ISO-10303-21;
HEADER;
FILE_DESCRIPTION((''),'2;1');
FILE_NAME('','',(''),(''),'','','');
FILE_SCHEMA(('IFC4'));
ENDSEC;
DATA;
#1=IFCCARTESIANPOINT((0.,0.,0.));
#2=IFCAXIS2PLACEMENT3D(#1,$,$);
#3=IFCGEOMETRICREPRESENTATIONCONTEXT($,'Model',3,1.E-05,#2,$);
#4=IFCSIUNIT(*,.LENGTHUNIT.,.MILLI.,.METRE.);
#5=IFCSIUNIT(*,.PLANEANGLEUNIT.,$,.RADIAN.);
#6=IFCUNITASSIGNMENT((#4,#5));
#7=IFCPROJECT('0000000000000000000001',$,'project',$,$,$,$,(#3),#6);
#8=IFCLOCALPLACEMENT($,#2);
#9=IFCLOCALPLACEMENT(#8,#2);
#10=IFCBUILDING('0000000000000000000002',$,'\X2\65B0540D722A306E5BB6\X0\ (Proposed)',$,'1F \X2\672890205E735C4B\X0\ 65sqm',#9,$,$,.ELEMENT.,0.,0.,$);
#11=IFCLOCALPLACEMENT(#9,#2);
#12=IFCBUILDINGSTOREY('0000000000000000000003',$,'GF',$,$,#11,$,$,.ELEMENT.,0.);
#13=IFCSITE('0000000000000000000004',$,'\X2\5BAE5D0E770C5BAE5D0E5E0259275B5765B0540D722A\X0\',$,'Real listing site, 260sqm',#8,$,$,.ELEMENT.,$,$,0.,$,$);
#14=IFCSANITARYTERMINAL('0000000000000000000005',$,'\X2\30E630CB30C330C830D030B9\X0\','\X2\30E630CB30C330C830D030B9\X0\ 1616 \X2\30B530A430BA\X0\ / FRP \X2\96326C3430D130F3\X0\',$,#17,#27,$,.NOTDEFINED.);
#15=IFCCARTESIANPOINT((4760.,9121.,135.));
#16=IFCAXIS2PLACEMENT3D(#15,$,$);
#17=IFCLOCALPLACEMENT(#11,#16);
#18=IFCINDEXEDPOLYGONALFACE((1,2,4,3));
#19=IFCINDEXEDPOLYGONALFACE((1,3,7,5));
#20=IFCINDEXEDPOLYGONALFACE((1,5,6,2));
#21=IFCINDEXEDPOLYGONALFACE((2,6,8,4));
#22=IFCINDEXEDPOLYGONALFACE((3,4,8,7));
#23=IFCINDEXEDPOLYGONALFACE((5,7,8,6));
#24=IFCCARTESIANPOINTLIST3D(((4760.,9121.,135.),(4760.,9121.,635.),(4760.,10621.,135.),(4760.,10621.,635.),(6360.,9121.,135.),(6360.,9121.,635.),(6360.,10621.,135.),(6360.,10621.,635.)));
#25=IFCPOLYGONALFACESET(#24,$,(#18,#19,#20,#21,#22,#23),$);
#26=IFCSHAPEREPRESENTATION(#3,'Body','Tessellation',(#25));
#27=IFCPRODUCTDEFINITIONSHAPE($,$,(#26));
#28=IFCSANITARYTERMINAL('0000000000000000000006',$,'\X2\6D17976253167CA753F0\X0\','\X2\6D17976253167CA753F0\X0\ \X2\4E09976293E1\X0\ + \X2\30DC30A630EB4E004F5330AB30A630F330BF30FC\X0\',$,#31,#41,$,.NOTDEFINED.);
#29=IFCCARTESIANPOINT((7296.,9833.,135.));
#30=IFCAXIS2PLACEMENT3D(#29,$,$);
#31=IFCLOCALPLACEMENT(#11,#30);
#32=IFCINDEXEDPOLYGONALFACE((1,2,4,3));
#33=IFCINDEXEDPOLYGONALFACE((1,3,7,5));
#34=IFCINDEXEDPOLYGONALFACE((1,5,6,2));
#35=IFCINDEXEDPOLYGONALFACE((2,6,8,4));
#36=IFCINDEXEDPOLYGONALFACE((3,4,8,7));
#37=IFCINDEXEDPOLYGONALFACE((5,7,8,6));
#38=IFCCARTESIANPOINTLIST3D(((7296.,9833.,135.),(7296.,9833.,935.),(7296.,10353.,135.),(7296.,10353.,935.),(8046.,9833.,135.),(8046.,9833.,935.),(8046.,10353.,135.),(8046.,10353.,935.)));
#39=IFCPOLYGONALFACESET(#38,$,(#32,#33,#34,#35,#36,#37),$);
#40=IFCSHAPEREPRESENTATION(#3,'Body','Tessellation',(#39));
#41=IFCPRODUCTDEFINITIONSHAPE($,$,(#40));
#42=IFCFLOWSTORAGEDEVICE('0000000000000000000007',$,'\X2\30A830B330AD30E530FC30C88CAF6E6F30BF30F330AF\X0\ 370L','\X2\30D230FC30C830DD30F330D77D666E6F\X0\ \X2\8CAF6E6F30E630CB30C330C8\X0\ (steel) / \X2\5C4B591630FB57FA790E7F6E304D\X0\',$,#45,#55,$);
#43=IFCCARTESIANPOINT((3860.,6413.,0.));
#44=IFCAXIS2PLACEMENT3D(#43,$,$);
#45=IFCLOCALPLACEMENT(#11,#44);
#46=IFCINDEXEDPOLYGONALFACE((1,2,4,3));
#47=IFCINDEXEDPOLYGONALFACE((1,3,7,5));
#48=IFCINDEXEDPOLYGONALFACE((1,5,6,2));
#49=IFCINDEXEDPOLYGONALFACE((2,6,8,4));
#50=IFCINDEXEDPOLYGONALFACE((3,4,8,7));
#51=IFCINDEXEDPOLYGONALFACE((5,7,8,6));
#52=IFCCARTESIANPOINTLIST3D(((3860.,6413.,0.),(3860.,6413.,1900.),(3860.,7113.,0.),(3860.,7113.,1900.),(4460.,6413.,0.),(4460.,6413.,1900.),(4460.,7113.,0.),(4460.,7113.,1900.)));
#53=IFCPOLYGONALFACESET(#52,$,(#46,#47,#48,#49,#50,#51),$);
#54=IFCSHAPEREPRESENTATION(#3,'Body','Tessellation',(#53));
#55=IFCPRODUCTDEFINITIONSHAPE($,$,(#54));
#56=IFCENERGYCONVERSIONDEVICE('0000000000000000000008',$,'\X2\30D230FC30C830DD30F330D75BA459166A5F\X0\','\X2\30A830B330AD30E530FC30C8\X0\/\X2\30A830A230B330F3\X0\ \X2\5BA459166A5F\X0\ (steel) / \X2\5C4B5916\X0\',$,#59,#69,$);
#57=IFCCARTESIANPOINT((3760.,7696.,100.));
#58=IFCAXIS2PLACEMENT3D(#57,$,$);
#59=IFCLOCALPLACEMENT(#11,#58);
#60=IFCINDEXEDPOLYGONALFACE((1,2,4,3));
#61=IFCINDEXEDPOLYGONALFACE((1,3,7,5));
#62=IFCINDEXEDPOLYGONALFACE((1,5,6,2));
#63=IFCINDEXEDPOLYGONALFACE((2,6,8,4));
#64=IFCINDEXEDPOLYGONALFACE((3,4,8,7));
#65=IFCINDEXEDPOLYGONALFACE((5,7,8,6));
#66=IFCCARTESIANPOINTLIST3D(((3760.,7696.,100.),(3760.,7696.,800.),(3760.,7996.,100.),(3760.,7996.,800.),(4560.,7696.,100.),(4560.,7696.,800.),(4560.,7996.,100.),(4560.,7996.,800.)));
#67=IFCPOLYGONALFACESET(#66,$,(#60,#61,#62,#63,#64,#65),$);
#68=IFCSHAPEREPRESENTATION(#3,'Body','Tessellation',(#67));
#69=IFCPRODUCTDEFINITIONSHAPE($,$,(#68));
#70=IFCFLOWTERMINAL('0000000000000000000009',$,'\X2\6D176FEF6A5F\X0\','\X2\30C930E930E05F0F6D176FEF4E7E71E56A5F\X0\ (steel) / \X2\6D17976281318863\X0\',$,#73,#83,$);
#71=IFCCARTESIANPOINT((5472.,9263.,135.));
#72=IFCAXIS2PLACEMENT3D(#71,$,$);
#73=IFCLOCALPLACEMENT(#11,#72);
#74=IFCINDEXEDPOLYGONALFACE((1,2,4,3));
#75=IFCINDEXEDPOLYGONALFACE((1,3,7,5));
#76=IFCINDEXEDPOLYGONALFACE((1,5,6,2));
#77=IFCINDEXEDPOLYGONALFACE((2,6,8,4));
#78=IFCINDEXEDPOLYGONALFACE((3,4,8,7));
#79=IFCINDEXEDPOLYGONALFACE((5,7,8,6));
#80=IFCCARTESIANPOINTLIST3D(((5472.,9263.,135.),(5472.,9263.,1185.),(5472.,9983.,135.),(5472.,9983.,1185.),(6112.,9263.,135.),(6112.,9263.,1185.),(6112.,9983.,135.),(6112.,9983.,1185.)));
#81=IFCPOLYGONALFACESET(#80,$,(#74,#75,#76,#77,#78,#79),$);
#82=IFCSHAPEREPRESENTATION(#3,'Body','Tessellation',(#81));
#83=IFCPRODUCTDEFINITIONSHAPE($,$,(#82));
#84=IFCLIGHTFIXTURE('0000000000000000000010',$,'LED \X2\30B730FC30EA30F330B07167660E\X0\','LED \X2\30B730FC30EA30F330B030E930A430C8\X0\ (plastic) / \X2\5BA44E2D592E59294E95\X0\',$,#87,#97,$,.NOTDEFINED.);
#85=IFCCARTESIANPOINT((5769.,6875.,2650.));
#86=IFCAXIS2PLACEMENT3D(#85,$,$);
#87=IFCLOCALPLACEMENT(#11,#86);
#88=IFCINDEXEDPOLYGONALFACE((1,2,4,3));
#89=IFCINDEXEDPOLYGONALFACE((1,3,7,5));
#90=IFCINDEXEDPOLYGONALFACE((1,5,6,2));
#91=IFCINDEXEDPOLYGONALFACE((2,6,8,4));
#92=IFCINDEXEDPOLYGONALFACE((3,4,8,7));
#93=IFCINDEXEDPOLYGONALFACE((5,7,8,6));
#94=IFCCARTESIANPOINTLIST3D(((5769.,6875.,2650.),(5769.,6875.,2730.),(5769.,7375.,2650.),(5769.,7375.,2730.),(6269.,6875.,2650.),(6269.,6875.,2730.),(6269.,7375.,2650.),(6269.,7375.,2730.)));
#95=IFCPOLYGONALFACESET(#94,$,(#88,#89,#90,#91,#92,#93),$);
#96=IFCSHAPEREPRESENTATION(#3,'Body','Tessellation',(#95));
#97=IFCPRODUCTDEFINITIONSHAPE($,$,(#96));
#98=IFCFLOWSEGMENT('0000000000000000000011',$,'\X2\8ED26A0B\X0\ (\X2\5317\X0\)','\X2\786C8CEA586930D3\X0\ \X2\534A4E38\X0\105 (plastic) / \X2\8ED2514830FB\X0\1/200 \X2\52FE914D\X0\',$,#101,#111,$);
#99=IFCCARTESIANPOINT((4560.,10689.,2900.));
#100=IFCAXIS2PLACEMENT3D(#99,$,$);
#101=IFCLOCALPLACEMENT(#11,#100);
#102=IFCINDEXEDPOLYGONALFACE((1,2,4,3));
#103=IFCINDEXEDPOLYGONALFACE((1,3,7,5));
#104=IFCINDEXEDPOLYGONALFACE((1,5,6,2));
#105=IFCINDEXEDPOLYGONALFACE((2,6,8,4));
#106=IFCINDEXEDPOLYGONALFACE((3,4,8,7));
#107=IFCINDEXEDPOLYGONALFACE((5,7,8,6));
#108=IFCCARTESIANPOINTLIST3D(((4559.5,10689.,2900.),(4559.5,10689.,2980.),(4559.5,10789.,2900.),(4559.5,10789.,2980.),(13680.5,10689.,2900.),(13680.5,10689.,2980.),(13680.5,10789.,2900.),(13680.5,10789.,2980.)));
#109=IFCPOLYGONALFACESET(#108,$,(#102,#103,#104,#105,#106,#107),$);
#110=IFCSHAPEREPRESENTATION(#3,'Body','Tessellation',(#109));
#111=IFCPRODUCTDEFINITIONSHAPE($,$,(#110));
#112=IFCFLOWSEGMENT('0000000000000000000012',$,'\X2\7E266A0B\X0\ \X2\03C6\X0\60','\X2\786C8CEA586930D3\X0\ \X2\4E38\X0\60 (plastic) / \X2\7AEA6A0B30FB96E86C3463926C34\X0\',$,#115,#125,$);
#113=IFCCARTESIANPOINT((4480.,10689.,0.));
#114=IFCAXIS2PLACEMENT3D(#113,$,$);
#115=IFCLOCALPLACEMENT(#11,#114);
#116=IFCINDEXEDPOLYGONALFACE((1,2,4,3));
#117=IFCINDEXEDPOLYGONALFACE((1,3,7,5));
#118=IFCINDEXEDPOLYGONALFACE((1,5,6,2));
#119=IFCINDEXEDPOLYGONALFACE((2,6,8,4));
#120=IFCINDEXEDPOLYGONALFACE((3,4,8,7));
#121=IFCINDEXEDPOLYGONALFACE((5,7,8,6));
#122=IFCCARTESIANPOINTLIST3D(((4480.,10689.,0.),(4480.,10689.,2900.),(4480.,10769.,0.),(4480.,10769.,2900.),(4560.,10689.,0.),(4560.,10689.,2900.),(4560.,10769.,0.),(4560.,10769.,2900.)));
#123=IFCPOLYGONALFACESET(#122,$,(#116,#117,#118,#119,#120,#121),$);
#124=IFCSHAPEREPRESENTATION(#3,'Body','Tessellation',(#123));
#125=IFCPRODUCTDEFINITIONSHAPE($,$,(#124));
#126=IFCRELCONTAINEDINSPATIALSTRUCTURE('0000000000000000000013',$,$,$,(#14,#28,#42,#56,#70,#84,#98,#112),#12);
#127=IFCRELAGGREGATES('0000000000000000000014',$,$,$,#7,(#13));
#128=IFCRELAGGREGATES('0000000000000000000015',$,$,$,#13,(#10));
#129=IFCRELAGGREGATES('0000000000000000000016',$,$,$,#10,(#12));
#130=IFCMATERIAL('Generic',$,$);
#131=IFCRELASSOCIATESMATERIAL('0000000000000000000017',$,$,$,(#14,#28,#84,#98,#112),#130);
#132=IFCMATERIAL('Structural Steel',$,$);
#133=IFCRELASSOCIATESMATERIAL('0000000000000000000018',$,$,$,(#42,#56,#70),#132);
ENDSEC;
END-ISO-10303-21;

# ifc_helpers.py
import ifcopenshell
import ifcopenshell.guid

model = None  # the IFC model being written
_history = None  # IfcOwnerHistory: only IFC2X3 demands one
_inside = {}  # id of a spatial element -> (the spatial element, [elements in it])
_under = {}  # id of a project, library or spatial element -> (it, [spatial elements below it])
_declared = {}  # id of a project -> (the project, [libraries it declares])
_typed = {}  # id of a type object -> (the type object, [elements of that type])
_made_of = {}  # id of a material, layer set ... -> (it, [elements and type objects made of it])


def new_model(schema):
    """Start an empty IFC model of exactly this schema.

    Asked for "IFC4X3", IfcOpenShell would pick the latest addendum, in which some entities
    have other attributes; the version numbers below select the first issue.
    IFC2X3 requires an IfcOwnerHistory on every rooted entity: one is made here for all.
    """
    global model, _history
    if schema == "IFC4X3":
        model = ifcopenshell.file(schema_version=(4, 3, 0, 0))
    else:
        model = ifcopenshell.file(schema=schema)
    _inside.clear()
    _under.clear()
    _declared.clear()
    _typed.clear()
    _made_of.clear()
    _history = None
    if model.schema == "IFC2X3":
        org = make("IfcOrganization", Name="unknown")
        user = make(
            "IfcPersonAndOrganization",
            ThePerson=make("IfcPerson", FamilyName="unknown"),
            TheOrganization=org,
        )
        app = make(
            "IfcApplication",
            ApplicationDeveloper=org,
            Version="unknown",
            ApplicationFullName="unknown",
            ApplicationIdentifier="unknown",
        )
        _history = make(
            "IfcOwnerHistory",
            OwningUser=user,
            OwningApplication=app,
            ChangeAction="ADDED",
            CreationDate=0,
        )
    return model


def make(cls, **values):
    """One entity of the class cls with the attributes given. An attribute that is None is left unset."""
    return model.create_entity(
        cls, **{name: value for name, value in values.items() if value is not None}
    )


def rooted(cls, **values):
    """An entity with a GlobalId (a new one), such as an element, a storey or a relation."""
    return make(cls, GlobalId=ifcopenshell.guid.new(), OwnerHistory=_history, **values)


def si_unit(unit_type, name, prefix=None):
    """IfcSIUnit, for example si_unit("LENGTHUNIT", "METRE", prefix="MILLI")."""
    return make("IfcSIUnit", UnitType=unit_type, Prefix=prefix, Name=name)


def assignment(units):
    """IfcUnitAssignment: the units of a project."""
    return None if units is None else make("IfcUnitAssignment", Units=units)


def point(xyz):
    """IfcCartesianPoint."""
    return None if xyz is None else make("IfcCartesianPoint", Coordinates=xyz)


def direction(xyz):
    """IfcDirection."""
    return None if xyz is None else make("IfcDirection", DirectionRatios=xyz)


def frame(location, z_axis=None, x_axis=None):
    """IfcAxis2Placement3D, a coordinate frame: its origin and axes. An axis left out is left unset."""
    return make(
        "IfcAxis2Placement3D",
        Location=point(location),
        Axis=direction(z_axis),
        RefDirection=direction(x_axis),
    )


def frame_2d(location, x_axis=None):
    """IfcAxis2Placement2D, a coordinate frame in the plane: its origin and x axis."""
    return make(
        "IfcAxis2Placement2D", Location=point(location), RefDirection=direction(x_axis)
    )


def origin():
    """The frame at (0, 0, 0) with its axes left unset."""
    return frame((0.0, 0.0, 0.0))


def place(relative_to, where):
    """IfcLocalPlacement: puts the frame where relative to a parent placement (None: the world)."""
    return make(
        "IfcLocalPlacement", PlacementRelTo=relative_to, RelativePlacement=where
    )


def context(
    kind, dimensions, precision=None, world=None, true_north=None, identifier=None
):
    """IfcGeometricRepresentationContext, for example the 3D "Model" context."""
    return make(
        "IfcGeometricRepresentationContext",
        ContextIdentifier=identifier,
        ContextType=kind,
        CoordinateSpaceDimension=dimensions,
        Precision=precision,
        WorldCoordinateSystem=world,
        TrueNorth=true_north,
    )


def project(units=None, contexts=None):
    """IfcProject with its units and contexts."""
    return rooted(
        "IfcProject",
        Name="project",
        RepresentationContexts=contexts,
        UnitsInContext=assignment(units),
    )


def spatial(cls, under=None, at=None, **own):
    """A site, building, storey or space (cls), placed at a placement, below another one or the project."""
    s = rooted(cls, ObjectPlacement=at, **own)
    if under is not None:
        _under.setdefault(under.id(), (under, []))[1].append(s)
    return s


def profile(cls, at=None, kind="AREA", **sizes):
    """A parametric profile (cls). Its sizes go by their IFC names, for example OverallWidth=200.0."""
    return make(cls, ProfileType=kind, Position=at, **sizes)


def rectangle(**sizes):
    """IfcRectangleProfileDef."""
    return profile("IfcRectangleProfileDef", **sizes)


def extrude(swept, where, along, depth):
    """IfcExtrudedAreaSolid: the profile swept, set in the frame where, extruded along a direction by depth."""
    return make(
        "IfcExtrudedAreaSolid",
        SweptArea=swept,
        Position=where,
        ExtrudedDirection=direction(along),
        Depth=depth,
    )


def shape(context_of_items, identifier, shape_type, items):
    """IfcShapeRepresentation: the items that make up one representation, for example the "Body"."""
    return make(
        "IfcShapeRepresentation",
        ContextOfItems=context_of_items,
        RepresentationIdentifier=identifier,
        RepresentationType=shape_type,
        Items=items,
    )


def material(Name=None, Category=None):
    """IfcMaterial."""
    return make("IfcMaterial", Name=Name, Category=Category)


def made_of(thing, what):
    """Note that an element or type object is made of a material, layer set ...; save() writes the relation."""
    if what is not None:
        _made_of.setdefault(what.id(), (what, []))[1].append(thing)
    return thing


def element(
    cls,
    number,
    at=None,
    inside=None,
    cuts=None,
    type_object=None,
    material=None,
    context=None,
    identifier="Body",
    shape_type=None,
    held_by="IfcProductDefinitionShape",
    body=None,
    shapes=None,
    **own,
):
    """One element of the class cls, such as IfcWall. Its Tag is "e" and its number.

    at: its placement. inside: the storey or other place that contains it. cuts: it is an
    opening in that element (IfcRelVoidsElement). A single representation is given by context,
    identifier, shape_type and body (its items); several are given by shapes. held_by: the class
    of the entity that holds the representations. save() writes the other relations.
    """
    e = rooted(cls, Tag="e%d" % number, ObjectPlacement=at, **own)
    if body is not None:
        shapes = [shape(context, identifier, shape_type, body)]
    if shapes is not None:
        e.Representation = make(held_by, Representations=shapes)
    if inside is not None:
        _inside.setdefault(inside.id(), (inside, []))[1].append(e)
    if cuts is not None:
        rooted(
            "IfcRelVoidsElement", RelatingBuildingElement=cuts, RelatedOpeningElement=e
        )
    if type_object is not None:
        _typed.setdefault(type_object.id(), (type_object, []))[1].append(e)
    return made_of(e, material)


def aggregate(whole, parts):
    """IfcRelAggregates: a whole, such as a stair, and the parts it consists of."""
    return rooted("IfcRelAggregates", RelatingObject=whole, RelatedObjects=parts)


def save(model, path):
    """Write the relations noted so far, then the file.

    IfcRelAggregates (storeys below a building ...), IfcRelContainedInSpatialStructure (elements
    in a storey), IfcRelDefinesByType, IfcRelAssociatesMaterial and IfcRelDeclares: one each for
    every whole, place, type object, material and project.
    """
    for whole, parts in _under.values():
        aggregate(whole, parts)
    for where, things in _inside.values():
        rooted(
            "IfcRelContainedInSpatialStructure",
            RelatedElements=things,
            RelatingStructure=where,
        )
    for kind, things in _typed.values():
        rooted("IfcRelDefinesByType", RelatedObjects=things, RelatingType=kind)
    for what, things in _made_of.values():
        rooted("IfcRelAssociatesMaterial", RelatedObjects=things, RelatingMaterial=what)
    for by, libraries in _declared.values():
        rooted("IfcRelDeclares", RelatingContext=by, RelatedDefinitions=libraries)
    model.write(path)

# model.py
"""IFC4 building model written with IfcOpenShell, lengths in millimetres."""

from ifc_helpers import new_model, si_unit, frame, frame_2d, origin, place, context, project, spatial, rectangle, extrude, material, element, save


model = new_model("IFC4")

# Units and contexts
model_context = context("Model", 3, precision=1e-05, world=origin())
ifc_project = project(units=[si_unit("LENGTHUNIT", "METRE", prefix="MILLI"), si_unit("PLANEANGLEUNIT", "RADIAN")], contexts=[model_context])

# Site, building, storey
site_placement = place(None, origin())
site = spatial("IfcSite", under=ifc_project, at=site_placement, Name="宮崎県宮崎市大字新名爪", ObjectType="Real listing site, 260sqm", CompositionType="ELEMENT", RefElevation=0.0)
building_placement = place(site_placement, origin())
building = spatial("IfcBuilding", under=site, at=building_placement, Name="新名爪の家 (Proposed)", ObjectType="1F 木造平屋 65sqm", CompositionType="ELEMENT", ElevationOfRefHeight=0.0, ElevationOfTerrain=0.0)
storey_placement = place(building_placement, origin())
storey = spatial("IfcBuildingStorey", under=building, at=storey_placement, Name="GF", CompositionType="ELEMENT", Elevation=0.0)

# Shared definitions
ifc_material_1 = material(Name="Structural Steel")

# Shared definitions
ifc_material_2 = material(Name="Generic")

# Sanitary terminals
sanitary_terminal_1_placement = place(storey_placement, frame((4760.0, 9121.0, 135.0)))
element("IfcSanitaryTerminal", 1, at=sanitary_terminal_1_placement, inside=storey, material=ifc_material_2, Name="ユニットバス", Description="ユニットバス 1616 サイズ / FRP 防水パン", PredefinedType="NOTDEFINED", context=model_context, shape_type="SweptSolid", body=[
    extrude(rectangle(XDim=1600.0, YDim=1500.0, at=frame_2d((800.0, 750.0))), frame((4760.0, 9121.0, 135.0)), (0.0, 0.0, 1.0), 500.0),
])
sanitary_terminal_2_placement = place(storey_placement, frame((7296.0, 9833.0, 135.0)))
element("IfcSanitaryTerminal", 2, at=sanitary_terminal_2_placement, inside=storey, material=ifc_material_2, Name="洗面化粧台", Description="洗面化粧台 三面鏡 + ボウル一体カウンター", PredefinedType="NOTDEFINED", context=model_context, shape_type="SweptSolid", body=[
    extrude(rectangle(XDim=750.0, YDim=520.0, at=frame_2d((375.0, 260.0))), frame((7296.0, 9833.0, 135.0)), (0.0, 0.0, 1.0), 800.0),
])

# Flow storage device
flow_storage_device_placement = place(storey_placement, frame((3860.0, 6413.0, 0.0)))
element("IfcFlowStorageDevice", 3, at=flow_storage_device_placement, inside=storey, material=ifc_material_1, Name="エコキュート貯湯タンク 370L", Description="ヒートポンプ給湯 貯湯ユニット (steel) / 屋外・基礎置き", context=model_context, shape_type="SweptSolid", body=[
    extrude(rectangle(XDim=600.0, YDim=700.0, at=frame_2d((300.0, 350.0))), frame((3860.0, 6413.0, 0.0)), (0.0, 0.0, 1.0), 1900.0),
])

# Energy conversion device
energy_conversion_device_placement = place(storey_placement, frame((3760.0, 7696.0, 100.0)))
element("IfcEnergyConversionDevice", 4, at=energy_conversion_device_placement, inside=storey, material=ifc_material_1, Name="ヒートポンプ室外機", Description="エコキュート/エアコン 室外機 (steel) / 屋外", context=model_context, shape_type="SweptSolid", body=[
    extrude(rectangle(XDim=800.0, YDim=300.0, at=frame_2d((400.0, 150.0))), frame((3760.0, 7696.0, 100.0)), (0.0, 0.0, 1.0), 700.0),
])

# Flow terminal
flow_terminal_placement = place(storey_placement, frame((5472.0, 9263.0, 135.0)))
element("IfcFlowTerminal", 5, at=flow_terminal_placement, inside=storey, material=ifc_material_1, Name="洗濯機", Description="ドラム式洗濯乾燥機 (steel) / 洗面脱衣", context=model_context, shape_type="SweptSolid", body=[
    extrude(rectangle(XDim=640.0, YDim=720.0, at=frame_2d((320.0, 360.0))), frame((5472.0, 9263.0, 135.0)), (0.0, 0.0, 1.0), 1050.0),
])

# Light fixture
light_fixture_placement = place(storey_placement, frame((5769.0, 6875.0, 2650.0)))
element("IfcLightFixture", 6, at=light_fixture_placement, inside=storey, material=ifc_material_2, Name="LED シーリング照明", Description="LED シーリングライト (plastic) / 室中央天井", PredefinedType="NOTDEFINED", context=model_context, shape_type="SweptSolid", body=[
    extrude(rectangle(XDim=500.0, YDim=500.0, at=frame_2d((250.0, 250.0))), frame((5769.0, 6875.0, 2650.0)), (0.0, 0.0, 1.0), 80.0),
])

# Flow segments
flow_segment_1_placement = place(storey_placement, frame((4560.0, 10689.0, 2900.0)))
element("IfcFlowSegment", 7, at=flow_segment_1_placement, inside=storey, material=ifc_material_2, Name="軒樋 (北)", Description="硬質塩ビ 半丸105 (plastic) / 軒先・1/200 勾配", context=model_context, shape_type="SweptSolid", body=[
    extrude(rectangle(XDim=9121.0, YDim=100.0, at=frame_2d((4560.0, 50.0))), frame((4560.0, 10689.0, 2900.0)), (0.0, 0.0, 1.0), 80.0),
])
flow_segment_2_placement = place(storey_placement, frame((4480.0, 10689.0, 0.0)))
element("IfcFlowSegment", 8, at=flow_segment_2_placement, inside=storey, material=ifc_material_2, Name="縦樋 φ60", Description="硬質塩ビ 丸60 (plastic) / 竪樋・雨水排水", context=model_context, shape_type="SweptSolid", body=[
    extrude(rectangle(XDim=80.0, YDim=80.0, at=frame_2d((40.0, 40.0))), frame((4480.0, 10689.0, 0.0)), (0.0, 0.0, 1.0), 2900.0),
])

save(model, "model.ifc")
